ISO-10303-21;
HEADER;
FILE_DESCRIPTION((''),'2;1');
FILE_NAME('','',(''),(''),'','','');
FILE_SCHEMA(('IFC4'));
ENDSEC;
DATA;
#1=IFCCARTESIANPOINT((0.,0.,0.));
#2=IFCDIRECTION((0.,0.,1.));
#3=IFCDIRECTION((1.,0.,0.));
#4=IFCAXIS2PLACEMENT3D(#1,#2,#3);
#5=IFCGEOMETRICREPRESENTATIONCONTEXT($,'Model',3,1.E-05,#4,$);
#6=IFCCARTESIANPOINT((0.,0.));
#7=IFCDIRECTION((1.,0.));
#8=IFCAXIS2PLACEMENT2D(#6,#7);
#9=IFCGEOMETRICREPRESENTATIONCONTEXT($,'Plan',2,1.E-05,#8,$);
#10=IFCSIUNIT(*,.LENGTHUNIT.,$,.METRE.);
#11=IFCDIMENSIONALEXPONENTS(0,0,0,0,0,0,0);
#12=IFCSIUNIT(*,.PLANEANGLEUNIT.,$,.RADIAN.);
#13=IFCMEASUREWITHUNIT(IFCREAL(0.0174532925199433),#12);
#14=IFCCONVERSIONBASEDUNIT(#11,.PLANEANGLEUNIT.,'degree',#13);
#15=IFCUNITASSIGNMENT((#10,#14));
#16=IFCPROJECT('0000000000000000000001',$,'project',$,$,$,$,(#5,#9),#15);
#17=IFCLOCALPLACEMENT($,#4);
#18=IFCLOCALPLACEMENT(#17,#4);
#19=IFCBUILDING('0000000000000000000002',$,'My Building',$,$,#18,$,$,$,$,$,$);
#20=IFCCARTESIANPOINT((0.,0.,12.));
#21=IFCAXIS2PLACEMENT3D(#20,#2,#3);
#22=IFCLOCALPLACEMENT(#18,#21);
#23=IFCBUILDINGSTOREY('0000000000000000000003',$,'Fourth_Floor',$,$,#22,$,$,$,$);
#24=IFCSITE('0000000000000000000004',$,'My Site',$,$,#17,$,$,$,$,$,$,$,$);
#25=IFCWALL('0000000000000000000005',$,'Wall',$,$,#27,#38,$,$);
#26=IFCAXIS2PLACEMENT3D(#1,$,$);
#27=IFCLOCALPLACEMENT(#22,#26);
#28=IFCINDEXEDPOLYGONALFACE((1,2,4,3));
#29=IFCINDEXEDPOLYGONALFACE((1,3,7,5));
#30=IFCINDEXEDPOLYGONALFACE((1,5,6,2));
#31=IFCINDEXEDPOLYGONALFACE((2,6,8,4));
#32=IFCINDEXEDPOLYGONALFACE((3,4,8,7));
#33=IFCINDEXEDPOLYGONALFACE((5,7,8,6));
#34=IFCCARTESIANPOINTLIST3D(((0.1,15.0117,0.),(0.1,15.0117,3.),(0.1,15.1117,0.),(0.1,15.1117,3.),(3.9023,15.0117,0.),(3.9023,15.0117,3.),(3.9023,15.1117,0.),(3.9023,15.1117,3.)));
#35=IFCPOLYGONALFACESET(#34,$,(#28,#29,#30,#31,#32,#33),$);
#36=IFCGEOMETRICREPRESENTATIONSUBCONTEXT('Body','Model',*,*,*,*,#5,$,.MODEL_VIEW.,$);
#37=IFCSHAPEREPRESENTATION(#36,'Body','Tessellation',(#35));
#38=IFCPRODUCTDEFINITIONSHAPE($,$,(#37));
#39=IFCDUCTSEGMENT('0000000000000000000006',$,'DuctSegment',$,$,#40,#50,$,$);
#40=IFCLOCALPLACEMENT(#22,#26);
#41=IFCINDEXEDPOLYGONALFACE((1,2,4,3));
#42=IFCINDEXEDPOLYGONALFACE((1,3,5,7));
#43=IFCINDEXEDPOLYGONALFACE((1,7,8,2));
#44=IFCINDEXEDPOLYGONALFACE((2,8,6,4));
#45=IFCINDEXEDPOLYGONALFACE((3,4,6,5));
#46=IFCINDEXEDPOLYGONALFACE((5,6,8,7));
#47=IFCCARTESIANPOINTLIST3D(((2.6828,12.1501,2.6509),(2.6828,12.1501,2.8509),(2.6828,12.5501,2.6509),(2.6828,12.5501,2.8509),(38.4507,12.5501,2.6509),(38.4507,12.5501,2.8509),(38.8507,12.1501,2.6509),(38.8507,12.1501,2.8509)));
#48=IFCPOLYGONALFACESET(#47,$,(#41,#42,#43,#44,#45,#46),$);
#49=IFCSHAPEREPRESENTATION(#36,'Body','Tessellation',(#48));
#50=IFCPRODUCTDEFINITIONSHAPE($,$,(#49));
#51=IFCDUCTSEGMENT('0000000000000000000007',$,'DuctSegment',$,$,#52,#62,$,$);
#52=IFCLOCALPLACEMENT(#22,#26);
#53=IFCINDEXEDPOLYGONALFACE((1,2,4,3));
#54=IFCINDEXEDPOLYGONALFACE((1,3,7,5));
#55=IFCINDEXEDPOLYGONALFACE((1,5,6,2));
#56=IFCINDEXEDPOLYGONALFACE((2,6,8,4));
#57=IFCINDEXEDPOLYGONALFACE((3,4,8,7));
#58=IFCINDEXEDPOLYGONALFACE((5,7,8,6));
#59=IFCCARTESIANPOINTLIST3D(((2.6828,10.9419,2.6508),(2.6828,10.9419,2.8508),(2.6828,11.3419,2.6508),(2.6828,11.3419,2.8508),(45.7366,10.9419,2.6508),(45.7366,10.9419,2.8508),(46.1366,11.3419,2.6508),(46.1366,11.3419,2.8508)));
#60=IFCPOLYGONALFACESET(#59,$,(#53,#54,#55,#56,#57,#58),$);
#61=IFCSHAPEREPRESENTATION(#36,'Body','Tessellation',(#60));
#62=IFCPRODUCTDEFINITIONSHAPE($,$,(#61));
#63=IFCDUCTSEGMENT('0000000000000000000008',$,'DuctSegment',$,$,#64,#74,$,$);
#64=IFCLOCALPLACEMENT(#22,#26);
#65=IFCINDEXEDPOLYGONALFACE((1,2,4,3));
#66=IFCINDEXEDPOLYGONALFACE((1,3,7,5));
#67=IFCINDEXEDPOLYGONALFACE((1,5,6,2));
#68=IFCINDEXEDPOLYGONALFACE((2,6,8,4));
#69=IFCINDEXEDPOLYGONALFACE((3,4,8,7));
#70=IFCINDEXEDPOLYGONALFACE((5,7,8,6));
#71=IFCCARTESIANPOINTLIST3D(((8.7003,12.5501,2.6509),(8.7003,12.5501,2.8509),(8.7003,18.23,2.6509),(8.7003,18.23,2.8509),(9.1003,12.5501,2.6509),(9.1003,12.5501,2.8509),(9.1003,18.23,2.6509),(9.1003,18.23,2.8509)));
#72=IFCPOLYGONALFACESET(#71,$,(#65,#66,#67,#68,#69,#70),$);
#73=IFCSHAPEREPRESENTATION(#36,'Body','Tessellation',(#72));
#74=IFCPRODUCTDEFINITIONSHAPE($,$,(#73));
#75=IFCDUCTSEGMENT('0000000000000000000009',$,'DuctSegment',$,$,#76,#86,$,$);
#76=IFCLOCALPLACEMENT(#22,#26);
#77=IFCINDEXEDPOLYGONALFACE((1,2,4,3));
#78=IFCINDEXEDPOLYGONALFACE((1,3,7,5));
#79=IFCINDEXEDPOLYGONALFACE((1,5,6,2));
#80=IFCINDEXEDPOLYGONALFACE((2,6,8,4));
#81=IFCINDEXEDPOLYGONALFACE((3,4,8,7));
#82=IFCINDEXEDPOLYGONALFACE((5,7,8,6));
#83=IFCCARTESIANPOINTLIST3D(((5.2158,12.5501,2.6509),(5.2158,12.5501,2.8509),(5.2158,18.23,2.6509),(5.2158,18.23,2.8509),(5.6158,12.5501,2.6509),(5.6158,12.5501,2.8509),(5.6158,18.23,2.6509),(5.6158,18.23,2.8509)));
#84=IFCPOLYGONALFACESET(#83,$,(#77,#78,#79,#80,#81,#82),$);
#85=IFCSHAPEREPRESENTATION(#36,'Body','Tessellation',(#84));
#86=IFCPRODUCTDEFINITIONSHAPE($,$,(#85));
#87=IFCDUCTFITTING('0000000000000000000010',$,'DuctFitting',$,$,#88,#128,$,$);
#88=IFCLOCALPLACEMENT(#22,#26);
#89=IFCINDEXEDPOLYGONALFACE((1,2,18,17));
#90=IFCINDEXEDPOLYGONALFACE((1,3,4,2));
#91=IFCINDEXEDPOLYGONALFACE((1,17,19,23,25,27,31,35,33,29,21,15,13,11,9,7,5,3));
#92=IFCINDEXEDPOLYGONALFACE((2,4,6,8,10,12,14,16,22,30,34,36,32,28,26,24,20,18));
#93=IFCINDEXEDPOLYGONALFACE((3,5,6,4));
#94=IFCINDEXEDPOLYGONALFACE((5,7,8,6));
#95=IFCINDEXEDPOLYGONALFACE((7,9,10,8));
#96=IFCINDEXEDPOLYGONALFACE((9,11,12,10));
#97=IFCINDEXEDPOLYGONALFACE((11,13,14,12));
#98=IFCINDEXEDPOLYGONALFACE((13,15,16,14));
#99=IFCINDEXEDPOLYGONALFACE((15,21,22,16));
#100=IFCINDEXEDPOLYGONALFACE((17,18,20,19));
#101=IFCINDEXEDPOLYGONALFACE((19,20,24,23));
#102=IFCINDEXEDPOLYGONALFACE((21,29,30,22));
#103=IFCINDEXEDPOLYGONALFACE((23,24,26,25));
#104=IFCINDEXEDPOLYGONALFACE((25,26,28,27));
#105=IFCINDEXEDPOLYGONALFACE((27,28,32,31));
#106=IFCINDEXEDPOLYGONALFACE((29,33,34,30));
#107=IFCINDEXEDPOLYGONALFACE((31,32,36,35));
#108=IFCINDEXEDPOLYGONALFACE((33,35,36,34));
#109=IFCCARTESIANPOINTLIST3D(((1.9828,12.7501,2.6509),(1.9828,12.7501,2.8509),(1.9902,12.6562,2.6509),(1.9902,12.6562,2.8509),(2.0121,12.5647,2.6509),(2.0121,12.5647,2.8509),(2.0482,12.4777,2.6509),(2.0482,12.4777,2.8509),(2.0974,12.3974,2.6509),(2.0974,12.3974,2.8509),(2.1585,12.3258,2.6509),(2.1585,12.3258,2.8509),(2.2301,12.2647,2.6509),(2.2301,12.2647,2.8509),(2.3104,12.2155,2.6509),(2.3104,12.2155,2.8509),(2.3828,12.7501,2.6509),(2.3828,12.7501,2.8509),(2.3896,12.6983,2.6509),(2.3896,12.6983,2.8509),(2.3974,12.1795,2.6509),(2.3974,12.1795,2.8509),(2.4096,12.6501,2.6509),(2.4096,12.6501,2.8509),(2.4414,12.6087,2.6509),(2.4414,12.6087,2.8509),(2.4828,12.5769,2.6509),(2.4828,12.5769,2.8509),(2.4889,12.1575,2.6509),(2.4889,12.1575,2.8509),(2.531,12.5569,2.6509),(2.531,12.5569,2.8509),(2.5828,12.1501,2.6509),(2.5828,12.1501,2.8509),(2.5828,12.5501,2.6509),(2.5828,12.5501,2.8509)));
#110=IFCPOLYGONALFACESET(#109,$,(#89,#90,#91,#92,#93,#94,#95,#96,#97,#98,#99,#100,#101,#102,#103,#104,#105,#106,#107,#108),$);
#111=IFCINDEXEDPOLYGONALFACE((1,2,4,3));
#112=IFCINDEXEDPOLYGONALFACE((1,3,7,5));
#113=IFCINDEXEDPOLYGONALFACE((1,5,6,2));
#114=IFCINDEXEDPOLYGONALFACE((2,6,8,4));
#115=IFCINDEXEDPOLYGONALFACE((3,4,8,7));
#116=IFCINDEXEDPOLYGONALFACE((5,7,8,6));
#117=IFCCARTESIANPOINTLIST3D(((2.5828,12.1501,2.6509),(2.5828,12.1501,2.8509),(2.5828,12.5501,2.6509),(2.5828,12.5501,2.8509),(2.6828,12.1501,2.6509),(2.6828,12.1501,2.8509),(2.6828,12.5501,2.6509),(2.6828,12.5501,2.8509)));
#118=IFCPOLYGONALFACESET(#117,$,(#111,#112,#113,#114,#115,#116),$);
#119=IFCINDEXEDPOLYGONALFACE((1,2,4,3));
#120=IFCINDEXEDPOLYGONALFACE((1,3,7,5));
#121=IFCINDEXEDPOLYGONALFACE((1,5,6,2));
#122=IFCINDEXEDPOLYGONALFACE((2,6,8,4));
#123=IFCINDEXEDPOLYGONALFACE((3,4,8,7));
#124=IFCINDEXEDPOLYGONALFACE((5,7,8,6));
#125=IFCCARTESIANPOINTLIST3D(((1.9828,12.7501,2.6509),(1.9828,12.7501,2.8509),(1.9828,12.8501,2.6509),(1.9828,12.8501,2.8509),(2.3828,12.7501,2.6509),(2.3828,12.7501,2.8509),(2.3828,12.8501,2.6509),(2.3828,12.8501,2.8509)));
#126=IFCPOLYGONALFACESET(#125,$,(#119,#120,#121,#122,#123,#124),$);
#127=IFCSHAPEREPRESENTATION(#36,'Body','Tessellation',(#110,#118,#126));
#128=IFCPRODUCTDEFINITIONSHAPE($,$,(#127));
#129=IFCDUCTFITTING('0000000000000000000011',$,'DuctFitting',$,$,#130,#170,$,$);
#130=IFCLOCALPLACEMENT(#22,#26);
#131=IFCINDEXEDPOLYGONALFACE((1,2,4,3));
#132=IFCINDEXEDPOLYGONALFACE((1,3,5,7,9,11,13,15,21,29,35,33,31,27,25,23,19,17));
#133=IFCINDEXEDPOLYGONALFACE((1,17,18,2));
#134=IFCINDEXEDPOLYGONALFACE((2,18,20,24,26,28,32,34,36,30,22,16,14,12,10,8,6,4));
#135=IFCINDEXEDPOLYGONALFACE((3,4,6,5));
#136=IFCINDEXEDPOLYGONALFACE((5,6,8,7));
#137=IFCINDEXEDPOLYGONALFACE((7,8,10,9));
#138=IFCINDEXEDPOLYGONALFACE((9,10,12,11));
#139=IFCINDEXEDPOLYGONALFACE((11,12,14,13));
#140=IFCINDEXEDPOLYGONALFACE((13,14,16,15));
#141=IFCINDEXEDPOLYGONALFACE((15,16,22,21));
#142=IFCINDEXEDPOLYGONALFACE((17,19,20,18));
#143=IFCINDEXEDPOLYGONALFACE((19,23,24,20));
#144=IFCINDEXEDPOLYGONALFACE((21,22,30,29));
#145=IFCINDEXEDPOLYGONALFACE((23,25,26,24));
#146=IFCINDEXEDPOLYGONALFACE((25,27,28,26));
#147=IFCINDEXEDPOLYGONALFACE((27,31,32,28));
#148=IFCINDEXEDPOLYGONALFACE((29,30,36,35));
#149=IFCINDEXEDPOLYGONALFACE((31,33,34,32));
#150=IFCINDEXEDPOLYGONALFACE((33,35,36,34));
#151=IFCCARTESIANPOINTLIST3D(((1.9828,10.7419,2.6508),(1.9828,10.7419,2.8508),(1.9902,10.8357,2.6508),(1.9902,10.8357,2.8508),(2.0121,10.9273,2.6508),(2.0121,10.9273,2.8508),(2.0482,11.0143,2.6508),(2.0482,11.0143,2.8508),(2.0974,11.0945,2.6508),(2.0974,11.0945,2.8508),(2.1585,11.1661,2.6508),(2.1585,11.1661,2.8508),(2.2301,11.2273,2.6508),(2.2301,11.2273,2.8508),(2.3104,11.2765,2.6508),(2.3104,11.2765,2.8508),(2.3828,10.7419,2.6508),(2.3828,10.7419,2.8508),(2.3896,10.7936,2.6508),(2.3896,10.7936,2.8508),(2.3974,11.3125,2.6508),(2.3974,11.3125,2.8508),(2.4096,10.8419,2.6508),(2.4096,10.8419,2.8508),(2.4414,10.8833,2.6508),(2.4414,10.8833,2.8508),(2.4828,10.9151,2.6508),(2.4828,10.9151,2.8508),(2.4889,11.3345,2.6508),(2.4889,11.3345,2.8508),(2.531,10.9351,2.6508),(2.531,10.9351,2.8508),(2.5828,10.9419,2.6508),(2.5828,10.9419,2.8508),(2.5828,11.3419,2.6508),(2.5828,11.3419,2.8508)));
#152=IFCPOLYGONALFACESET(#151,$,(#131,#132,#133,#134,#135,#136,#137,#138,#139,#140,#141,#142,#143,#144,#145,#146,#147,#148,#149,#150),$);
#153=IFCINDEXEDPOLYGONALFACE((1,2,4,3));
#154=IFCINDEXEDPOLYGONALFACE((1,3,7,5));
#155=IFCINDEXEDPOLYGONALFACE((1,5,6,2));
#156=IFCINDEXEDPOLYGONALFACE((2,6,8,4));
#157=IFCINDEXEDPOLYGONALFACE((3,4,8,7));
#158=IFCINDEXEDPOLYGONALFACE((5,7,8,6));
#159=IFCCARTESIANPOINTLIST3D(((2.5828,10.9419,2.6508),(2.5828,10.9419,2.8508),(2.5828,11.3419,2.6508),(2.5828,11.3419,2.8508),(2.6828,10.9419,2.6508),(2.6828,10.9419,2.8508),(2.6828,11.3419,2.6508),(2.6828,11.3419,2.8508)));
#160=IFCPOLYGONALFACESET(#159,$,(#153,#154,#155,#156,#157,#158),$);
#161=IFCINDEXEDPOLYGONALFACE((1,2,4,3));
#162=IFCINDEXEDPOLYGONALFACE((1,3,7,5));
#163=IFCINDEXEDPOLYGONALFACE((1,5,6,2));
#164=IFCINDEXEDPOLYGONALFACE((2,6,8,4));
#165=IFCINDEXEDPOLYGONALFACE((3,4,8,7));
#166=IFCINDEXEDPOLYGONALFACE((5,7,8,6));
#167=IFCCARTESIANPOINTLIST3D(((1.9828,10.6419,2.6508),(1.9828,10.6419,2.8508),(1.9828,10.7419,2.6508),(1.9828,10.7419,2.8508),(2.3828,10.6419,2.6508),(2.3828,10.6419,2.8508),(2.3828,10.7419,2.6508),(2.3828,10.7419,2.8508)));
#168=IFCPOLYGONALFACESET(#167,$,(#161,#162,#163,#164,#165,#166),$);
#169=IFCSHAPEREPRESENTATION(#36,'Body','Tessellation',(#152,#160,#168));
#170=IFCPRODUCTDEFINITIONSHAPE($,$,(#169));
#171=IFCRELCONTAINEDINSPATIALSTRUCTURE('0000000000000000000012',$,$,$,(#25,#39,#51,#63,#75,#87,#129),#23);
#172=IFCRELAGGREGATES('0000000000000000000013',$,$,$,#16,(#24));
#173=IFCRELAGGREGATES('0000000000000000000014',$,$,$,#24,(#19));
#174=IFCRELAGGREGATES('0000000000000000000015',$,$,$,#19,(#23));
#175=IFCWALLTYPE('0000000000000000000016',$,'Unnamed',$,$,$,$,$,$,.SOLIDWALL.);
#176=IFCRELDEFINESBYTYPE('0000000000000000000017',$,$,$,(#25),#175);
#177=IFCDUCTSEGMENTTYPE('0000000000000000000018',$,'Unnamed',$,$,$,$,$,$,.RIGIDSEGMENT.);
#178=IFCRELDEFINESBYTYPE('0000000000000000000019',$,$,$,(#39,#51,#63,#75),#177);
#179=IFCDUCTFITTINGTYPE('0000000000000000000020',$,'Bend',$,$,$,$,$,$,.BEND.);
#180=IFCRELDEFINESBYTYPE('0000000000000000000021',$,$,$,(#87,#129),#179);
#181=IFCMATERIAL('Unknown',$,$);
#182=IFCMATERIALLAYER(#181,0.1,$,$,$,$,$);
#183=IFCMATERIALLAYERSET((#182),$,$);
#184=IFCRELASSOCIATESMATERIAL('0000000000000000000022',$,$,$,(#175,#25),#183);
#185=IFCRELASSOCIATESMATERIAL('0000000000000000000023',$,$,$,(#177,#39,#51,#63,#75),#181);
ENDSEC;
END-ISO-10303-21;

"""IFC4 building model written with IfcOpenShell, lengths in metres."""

from ifc_helpers import new_model, entity, si_unit, converted_unit, frame, origin_with_axes, origin_2d_with_axis, place, context, subcontext, project, spatial, line, arc, indexed_curve, rectangle, outline, extrude, clip, halfspace, source, transform, mapped, material, layer, layer_set, layer_usage, material_profile, profile_set, profile_usage, type_object, type_shapes, element, save


model = new_model("IFC4")

# Units and contexts
model_context = context("Model", 3, precision=1e-05, world=origin_with_axes())
plan_context = context("Plan", 2, precision=1e-05, world=origin_2d_with_axis())
body_context_1 = subcontext(model_context, "Body", "Model", "MODEL_VIEW")
ifc_project = project(units=[si_unit("LENGTHUNIT", "METRE"), converted_unit("PLANEANGLEUNIT", "degree", entity("IfcReal", 0.0174532925199433), si_unit("PLANEANGLEUNIT", "RADIAN"), dimensions=[0, 0, 0, 0, 0, 0, 0])], contexts=[model_context, plan_context])

# Site, building, storey
site_placement = place(None, origin_with_axes())
site = spatial("IfcSite", under=ifc_project, at=site_placement, Name="My Site")
building_placement = place(site_placement, origin_with_axes())
building = spatial("IfcBuilding", under=site, at=building_placement, Name="My Building")
storey_placement = place(building_placement, frame((0.0, 0.0, 12.0), z_axis=(0.0, 0.0, 1.0), x_axis=(1.0, 0.0, 0.0)))
storey = spatial("IfcBuildingStorey", under=building, at=storey_placement, Name="Fourth_Floor")

# Shared definitions
ifc_material = material(Name="Unknown")
ifc_layer = layer(ifc_material, 0.1)
ifc_layer_set = layer_set([ifc_layer])
wall_type = type_object("IfcWallType", Name="Unnamed", PredefinedType="SOLIDWALL", material=ifc_layer_set)

# Wall
ifc_layer_usage_1 = layer_usage(ifc_layer_set, "AXIS2", "POSITIVE", 0.0)
wall_1_placement = place(storey_placement, frame((0.1, 15.0117, 0.0), z_axis=(0.0, 0.0, 1.0), x_axis=(1.0, 0.0, 0.0)))
element("IfcWall", 1, at=wall_1_placement, inside=storey, type_object=wall_type, material=ifc_layer_usage_1, Name="Wall", context=body_context_1, shape_type="SweptSolid", body=[
    extrude(outline(indexed_curve([(0.0, 0.0), (0.0, 0.1), (3.8023, 0.1), (3.8023, 0.0)], segments=[line(1, 2, 3, 4, 1)])), origin_with_axes(), (0.0, 0.0, 1.0), 3.0),
])

# Duct segments
ifc_material_profile_1 = material_profile(ifc_material, rectangle(XDim=0.4, YDim=0.2))
ifc_profile_set_1 = profile_set([ifc_material_profile_1])
ifc_profile_usage_1 = profile_usage(ifc_profile_set_1, cardinal=5)
duct_segment_type = type_object("IfcDuctSegmentType", Name="Unnamed", PredefinedType="RIGIDSEGMENT", material=ifc_profile_set_1)
duct_segment_1_placement = place(storey_placement, frame((2.6828, 12.3501, 2.7509), z_axis=(1.0, 0.0, 0.0), x_axis=(0.0, 1.0, 0.0)))
element("IfcDuctSegment", 2, at=duct_segment_1_placement, inside=storey, type_object=duct_segment_type, material=ifc_profile_usage_1, Name="DuctSegment", context=body_context_1, shape_type="Clipping", body=[
    clip(extrude(rectangle(XDim=0.4, YDim=0.2), origin_with_axes(), (0.0, 0.0, 1.0), 36.1679), halfspace(frame((-0.2, -6.1001, 36.1679), z_axis=(0.707109, 0.0, 0.707105), x_axis=(0.0, -1.0, 0.0)), False)),
])
ifc_profile_usage_2 = profile_usage(ifc_profile_set_1, cardinal=5)
duct_segment_2_placement = place(storey_placement, frame((2.6828, 11.1419, 2.7508), z_axis=(1.0, 0.0, 0.0), x_axis=(0.0, 1.0, 0.0)))
element("IfcDuctSegment", 3, at=duct_segment_2_placement, inside=storey, type_object=duct_segment_type, material=ifc_profile_usage_2, Name="DuctSegment", context=body_context_1, shape_type="Clipping", body=[
    clip(extrude(rectangle(XDim=0.4, YDim=0.2), origin_with_axes(), (0.0, 0.0, 1.0), 43.4538), halfspace(frame((0.2, -6.1, 43.4538), z_axis=(-0.707109, 0.0, 0.707104), x_axis=(0.0, 1.0, 0.0)), False)),
])
ifc_profile_usage_3 = profile_usage(ifc_profile_set_1, cardinal=5)
duct_segment_3_placement = place(storey_placement, frame((8.9003, 12.5501, 2.7509), z_axis=(0.0, 1.0, 0.0), x_axis=(-1.0, 0.0, 0.0)))
element("IfcDuctSegment", 4, at=duct_segment_3_placement, inside=storey, type_object=duct_segment_type, material=ifc_profile_usage_3, Name="DuctSegment", context=body_context_1, shape_type="SweptSolid", body=[
    extrude(rectangle(XDim=0.4, YDim=0.2), origin_with_axes(), (0.0, 0.0, 1.0), 5.6799),
])
ifc_profile_usage_4 = profile_usage(ifc_profile_set_1, cardinal=5)
duct_segment_4_placement = place(storey_placement, frame((5.4158, 12.5501, 2.7509), z_axis=(0.0, 1.0, 0.0), x_axis=(-1.0, 0.0, 0.0)))
element("IfcDuctSegment", 5, at=duct_segment_4_placement, inside=storey, type_object=duct_segment_type, material=ifc_profile_usage_4, Name="DuctSegment", context=body_context_1, shape_type="SweptSolid", body=[
    extrude(rectangle(XDim=0.4, YDim=0.2), origin_with_axes(), (0.0, 0.0, 1.0), 5.6799),
])

# Duct fittings
duct_fitting_type = type_object("IfcDuctFittingType", Name="Bend", PredefinedType="BEND")
shared_shape_1 = source(origin_with_axes(), body_context_1, "Body", "SweptSolid", [
    extrude(outline(indexed_curve([(0.2, 0.0), (0.2586, 0.1414), (0.4, 0.2), (0.4, 0.6), (-0.0243, 0.4243), (-0.2, 0.0)], segments=[arc(1, 2, 3), line(3, 4), arc(4, 5, 6), line(6, 1)])), frame((0.0, -0.1, 0.1), z_axis=(0.0, -1.0, 0.0), x_axis=(1.0, 0.0, 0.0)), (0.0, 0.0, -1.0), 0.2),
    extrude(rectangle(XDim=0.4, YDim=0.2), origin_with_axes(), (0.0, 0.0, 1.0), 0.1),
    extrude(rectangle(XDim=0.4, YDim=0.2), frame((0.4, 0.0, 0.5), z_axis=(1.0, 0.0, 0.0), x_axis=(0.0, 0.0, 1.0)), (0.0, 0.0, 1.0), 0.1),
])
type_shapes(duct_fitting_type, [shared_shape_1])
for number, where, z_axis, x_axis, name in (
    (6, (2.6828, 12.3501, 2.7509), (-1.0, 0.0, 0.0), (0.0, 1.0, 0.0), "DuctFitting"),
    (7, (2.6828, 11.1419, 2.7508), (-1.0, 0.0, 0.0), (0.0, -1.0, 0.0), "DuctFitting"),
):
    element("IfcDuctFitting", number, at=place(storey_placement, frame(where, z_axis=z_axis, x_axis=x_axis)), inside=storey, type_object=duct_fitting_type, Name=name, context=body_context_1, shape_type="MappedRepresentation", body=[
        mapped(shared_shape_1, transform((0.0, 0.0, 0.0), x_axis=(1.0, 0.0, 0.0), y_axis=(0.0, 1.0, 0.0), z_axis=(0.0, 0.0, 1.0), scale=1.0)),
    ])

save(model, "model.ifc")
